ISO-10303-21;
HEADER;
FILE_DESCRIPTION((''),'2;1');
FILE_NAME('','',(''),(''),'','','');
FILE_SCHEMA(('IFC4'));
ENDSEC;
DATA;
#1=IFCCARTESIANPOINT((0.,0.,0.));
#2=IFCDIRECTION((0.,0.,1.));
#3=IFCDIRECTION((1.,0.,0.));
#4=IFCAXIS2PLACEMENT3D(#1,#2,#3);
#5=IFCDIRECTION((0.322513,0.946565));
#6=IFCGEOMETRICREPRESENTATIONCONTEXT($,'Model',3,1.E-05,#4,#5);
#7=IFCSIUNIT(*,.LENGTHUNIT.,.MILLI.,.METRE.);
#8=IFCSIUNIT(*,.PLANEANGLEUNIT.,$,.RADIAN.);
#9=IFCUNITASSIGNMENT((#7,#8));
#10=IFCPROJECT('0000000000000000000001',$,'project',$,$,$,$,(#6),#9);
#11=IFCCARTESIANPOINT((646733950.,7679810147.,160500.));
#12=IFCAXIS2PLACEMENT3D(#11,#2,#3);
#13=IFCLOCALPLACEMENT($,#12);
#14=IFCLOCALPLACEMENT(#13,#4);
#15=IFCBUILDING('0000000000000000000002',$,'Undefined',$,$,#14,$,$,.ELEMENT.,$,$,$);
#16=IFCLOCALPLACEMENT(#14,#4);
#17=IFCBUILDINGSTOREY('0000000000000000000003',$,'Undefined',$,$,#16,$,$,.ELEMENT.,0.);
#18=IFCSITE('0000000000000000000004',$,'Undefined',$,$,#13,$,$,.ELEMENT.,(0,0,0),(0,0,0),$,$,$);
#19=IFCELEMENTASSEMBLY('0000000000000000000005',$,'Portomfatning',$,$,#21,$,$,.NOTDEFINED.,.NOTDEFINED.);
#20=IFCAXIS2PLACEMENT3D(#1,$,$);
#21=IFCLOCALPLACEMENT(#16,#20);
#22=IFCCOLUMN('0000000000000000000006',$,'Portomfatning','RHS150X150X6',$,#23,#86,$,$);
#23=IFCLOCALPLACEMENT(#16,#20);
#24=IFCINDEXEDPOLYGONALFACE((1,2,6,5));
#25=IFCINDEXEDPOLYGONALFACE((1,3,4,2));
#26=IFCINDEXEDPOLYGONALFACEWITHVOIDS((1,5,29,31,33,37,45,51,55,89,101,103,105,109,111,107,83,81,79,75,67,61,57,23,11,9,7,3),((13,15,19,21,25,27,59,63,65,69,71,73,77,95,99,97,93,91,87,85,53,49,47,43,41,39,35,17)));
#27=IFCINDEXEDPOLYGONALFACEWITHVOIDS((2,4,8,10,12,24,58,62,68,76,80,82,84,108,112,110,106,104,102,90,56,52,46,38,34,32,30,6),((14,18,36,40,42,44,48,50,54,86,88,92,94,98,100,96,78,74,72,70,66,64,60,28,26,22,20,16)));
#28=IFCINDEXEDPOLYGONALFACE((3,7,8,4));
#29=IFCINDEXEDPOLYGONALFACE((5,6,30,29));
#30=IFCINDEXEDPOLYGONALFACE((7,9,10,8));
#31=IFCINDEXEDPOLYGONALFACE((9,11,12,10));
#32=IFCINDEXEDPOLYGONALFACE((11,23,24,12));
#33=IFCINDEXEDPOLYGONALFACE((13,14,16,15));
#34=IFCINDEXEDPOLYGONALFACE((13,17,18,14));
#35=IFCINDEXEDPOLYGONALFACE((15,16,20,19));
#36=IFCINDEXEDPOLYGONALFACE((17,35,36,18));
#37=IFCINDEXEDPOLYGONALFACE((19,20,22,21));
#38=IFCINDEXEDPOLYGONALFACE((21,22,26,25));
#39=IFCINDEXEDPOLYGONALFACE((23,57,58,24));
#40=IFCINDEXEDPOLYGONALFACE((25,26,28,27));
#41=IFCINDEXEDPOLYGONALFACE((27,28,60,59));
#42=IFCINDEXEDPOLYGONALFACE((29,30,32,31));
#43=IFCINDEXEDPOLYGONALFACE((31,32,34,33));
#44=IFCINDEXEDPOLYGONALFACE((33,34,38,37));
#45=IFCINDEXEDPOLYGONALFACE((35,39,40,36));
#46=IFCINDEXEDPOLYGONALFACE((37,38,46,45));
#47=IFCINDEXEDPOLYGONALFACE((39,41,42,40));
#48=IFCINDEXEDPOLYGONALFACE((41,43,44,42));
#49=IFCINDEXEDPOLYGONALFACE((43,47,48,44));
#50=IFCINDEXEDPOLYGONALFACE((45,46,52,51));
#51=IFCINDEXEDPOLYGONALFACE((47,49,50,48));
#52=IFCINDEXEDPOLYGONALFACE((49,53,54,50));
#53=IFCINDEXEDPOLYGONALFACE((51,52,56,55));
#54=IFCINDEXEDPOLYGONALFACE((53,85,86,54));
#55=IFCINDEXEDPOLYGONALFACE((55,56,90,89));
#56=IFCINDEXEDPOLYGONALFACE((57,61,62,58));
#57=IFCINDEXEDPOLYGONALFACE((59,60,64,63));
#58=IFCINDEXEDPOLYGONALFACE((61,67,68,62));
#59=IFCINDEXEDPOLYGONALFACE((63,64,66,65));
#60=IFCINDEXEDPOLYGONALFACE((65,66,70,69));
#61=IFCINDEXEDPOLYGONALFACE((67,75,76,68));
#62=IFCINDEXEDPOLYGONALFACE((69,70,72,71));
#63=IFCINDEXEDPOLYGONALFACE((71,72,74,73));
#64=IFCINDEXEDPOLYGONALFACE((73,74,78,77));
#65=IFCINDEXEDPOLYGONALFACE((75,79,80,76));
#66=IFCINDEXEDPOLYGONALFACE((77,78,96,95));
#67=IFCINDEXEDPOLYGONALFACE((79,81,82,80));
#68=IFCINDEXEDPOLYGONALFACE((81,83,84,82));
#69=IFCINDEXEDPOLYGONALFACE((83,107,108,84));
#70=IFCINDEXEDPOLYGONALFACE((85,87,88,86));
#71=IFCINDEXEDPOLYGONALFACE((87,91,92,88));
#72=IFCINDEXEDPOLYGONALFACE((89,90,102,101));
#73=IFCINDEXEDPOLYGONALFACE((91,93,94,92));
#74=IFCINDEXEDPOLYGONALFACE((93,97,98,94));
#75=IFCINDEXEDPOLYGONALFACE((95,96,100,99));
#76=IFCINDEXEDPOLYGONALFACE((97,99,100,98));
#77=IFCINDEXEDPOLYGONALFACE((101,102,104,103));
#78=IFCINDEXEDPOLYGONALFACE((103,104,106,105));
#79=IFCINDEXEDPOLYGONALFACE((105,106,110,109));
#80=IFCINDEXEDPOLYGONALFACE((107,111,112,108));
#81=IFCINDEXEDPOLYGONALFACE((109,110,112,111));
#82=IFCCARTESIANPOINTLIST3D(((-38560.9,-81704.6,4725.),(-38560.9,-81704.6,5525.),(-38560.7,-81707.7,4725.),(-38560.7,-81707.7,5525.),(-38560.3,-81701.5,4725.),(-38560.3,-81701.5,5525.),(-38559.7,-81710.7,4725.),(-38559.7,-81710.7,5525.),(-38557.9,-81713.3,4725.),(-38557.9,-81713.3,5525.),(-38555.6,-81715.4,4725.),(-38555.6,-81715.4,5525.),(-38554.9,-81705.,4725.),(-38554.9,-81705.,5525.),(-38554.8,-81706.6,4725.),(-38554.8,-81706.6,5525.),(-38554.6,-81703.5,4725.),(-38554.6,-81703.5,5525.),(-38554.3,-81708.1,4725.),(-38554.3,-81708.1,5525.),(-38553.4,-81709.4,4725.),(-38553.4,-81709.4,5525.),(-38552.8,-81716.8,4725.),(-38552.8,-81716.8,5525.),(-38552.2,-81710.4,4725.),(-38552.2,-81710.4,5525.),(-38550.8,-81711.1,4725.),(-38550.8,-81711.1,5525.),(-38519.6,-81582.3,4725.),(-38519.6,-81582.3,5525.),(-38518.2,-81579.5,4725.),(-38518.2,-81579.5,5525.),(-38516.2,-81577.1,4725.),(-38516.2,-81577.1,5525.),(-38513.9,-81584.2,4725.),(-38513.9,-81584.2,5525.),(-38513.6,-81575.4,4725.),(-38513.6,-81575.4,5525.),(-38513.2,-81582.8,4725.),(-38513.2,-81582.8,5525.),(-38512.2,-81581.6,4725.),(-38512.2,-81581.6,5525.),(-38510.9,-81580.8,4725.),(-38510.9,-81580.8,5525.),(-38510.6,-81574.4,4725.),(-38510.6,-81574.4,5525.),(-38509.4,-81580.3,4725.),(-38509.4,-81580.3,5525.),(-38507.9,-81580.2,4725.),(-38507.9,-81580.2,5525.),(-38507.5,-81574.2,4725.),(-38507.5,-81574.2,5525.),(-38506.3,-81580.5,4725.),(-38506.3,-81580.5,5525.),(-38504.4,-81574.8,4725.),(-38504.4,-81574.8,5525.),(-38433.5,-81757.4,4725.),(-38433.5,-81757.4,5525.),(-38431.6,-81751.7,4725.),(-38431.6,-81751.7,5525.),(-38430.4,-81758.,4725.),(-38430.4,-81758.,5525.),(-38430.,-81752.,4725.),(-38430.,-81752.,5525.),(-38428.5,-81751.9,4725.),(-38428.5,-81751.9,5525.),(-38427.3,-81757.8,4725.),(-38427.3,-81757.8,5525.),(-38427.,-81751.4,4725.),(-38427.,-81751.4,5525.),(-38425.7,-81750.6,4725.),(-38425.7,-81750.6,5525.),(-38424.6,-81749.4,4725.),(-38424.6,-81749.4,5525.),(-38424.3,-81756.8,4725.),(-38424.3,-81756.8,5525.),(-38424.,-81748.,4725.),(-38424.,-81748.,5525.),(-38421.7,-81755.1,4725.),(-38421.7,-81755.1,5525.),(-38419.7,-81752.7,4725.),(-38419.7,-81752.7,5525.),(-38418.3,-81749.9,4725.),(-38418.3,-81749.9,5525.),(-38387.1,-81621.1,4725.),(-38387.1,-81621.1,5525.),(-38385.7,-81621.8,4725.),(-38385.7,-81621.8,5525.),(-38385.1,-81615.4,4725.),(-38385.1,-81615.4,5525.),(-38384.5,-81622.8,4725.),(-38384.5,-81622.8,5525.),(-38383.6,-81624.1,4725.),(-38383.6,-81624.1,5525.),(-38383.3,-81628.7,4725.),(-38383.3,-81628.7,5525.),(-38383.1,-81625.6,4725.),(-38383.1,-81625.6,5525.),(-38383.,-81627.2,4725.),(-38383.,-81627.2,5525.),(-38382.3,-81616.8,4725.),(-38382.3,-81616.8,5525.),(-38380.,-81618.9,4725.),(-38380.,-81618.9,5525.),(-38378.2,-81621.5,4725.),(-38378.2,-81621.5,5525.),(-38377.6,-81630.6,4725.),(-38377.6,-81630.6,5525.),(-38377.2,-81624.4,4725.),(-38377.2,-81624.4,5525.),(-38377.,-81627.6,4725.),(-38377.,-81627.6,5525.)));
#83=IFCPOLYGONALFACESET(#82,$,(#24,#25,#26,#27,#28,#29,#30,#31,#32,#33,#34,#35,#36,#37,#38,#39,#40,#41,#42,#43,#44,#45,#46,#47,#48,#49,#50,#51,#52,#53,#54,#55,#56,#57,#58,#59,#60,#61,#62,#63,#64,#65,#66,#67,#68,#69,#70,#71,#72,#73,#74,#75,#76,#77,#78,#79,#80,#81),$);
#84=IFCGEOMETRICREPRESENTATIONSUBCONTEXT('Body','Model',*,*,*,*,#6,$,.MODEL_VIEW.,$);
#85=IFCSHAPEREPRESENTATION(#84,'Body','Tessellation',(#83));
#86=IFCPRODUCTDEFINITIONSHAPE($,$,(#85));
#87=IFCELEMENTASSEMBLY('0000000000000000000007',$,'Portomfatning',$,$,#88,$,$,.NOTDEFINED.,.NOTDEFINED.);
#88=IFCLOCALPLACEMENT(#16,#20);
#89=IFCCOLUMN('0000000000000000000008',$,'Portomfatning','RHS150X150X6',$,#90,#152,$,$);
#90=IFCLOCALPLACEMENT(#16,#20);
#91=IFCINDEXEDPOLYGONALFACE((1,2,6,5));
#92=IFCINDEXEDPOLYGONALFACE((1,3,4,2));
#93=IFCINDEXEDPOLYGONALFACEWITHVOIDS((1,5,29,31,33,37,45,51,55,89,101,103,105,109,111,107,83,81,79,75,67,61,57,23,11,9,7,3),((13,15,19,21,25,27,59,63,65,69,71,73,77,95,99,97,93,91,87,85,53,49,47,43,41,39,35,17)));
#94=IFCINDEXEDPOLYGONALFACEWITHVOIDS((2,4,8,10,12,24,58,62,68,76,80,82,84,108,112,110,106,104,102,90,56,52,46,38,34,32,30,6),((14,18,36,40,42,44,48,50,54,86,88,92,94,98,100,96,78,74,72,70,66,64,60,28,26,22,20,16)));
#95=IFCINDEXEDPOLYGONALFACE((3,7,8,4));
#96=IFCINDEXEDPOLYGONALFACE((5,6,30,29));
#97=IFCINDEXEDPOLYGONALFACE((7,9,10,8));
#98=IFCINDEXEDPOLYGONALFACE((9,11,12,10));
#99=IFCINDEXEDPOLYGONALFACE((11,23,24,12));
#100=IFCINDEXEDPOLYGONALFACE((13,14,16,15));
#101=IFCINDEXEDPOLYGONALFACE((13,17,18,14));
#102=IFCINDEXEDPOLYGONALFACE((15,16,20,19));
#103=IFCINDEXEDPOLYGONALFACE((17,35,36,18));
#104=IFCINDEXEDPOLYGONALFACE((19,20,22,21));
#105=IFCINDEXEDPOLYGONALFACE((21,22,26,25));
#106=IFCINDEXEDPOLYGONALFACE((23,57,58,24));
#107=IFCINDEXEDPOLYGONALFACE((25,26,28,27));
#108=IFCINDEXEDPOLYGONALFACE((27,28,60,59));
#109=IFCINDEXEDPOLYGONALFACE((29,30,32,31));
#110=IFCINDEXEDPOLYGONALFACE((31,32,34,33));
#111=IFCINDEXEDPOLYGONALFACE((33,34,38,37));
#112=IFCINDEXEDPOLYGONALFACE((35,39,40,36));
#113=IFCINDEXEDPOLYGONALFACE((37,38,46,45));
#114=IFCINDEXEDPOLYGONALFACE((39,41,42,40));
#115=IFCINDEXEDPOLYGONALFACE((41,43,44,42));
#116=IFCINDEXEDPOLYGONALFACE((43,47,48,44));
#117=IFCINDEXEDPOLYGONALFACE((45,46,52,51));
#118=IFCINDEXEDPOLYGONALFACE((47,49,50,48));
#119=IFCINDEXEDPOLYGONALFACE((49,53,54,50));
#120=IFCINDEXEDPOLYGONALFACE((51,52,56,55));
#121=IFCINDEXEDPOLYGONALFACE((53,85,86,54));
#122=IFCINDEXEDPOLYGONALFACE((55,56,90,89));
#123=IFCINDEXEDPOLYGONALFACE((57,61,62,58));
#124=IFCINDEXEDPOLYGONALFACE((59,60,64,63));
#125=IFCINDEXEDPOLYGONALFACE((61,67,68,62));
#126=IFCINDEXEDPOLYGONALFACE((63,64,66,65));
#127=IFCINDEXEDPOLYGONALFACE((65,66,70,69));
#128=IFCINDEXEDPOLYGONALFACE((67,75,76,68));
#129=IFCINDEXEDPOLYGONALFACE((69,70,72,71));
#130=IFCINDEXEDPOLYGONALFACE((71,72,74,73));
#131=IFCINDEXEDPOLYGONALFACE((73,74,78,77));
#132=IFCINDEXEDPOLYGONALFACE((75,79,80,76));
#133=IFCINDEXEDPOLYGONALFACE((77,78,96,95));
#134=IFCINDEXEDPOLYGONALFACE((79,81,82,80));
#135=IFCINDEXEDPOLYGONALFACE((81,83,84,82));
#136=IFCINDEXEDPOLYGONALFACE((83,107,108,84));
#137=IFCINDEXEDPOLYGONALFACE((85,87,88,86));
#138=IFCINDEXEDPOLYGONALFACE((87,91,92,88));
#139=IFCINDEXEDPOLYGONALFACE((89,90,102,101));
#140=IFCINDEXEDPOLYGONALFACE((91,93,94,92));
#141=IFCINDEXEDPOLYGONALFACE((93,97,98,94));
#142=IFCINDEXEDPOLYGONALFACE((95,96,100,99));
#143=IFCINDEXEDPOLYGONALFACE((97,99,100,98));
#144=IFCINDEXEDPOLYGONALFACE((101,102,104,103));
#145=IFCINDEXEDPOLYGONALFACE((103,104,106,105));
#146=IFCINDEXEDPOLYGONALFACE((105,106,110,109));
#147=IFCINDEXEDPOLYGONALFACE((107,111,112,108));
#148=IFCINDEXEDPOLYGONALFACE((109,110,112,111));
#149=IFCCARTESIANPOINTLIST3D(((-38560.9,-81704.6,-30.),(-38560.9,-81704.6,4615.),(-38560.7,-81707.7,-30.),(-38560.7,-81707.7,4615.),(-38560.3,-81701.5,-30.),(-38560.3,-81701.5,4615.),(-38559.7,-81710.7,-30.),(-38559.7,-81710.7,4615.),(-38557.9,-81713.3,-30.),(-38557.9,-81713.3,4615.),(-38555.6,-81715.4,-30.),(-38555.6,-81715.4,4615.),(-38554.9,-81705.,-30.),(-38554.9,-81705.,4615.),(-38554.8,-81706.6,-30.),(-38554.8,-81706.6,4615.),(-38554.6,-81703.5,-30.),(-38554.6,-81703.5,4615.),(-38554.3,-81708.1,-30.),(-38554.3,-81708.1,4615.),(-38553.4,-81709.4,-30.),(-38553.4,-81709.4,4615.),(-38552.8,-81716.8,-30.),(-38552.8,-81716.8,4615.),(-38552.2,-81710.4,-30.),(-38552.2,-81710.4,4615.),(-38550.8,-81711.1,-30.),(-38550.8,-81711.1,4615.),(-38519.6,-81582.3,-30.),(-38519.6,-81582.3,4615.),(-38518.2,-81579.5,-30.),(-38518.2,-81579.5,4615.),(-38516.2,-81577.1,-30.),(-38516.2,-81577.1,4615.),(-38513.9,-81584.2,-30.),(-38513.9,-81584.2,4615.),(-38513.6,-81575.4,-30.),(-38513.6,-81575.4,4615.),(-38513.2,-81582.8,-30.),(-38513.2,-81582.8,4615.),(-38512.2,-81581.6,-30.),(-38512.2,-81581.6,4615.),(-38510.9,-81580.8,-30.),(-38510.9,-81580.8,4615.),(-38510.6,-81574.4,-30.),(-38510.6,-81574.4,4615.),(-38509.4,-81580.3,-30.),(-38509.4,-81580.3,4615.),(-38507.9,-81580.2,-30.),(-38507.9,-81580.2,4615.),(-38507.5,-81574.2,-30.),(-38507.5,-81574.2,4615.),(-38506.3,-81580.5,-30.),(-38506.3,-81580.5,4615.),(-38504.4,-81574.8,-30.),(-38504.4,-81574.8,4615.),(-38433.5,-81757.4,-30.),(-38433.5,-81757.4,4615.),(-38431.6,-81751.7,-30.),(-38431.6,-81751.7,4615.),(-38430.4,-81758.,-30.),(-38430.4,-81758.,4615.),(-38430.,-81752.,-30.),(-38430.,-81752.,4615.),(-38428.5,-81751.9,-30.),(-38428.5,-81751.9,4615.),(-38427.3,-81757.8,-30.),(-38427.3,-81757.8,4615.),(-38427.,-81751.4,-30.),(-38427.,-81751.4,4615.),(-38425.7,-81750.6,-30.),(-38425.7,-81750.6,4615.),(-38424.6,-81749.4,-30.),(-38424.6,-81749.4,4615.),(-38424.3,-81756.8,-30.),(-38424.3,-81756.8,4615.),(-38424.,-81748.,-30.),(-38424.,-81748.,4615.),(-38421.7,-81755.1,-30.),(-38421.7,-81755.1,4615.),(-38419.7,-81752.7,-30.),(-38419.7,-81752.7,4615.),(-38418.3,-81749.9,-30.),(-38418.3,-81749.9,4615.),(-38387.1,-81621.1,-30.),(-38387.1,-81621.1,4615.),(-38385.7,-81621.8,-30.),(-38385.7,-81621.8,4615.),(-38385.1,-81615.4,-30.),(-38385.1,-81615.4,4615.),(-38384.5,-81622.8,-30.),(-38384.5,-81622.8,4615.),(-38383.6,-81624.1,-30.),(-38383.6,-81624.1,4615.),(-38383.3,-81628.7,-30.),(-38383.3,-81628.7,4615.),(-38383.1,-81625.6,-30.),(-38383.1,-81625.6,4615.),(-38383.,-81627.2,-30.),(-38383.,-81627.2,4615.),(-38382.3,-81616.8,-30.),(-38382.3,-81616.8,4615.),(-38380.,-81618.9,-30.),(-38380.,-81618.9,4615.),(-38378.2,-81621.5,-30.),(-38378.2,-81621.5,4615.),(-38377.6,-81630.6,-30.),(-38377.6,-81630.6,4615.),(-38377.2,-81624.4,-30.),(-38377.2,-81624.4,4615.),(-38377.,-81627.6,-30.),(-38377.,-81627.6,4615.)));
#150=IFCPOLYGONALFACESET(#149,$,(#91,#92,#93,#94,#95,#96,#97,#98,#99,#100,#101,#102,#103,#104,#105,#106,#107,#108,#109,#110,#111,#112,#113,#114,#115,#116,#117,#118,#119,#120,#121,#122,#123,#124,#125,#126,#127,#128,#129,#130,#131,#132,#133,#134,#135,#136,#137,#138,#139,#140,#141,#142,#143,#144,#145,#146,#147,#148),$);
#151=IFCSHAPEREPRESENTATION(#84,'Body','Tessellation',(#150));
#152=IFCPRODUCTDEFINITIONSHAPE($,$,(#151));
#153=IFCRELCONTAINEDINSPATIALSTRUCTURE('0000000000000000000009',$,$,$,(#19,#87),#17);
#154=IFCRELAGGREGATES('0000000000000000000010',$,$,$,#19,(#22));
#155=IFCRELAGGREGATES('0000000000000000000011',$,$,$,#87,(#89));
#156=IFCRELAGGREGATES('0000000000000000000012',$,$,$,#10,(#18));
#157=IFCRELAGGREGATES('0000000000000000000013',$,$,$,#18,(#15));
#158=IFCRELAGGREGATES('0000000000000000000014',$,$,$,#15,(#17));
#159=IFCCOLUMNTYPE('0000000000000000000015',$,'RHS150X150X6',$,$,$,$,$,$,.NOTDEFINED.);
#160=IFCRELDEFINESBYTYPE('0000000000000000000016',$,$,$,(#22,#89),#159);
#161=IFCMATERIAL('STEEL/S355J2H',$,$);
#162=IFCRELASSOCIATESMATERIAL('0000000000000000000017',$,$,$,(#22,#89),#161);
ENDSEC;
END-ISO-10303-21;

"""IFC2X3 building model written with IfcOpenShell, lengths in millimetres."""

from ifc_helpers import new_model, si_unit, direction, frame, origin_with_axes, origin_2d_with_axis, place, context, subcontext, project, spatial, hollow_rectangle, extrude, clip, halfspace, material, type_object, element, aggregate, save


model = new_model("IFC2X3")

# Units and contexts
model_context = context("Model", 3, precision=1e-05, world=origin_with_axes(), true_north=direction((0.322513, 0.946565)))
body_context = subcontext(model_context, "Body", "Model", "MODEL_VIEW")
ifc_project = project(units=[si_unit("LENGTHUNIT", "METRE", prefix="MILLI"), si_unit("PLANEANGLEUNIT", "RADIAN")], contexts=[model_context])

# Site, building, storey
site_placement = place(None, frame((646733950.0, 7679810147.0, 160500.0), z_axis=(0.0, 0.0, 1.0), x_axis=(1.0, 0.0, 0.0)))
site = spatial("IfcSite", under=ifc_project, at=site_placement, Name="Undefined", CompositionType="ELEMENT", RefLatitude=(0, 0, 0), RefLongitude=(0, 0, 0))
building_placement = place(site_placement, origin_with_axes())
building = spatial("IfcBuilding", under=site, at=building_placement, Name="Undefined", CompositionType="ELEMENT")
storey_placement = place(building_placement, origin_with_axes())
storey = spatial("IfcBuildingStorey", under=building, at=storey_placement, Name="Undefined", CompositionType="ELEMENT", Elevation=0.0)

# Element assembly, column
assembly_1_placement = place(storey_placement, origin_with_axes())
assembly_1 = element("IfcElementAssembly", 1, at=assembly_1_placement, inside=storey, Name="Portomfatning", AssemblyPlace="NOTDEFINED", PredefinedType="NOTDEFINED")
ifc_material_1 = material(Name="STEEL/S355J2H")
column_type_1 = type_object("IfcColumnType", Name="RHS150X150X6", PredefinedType="NOTDEFINED")
column_1_placement = place(assembly_1_placement, frame((-38468.9, -81666.1, 4725.0), z_axis=(0.0, 0.0, 1.0), x_axis=(0.946565, -0.322513, 0.0)))
column_1 = element("IfcColumn", 2, at=column_1_placement, type_object=column_type_1, material=ifc_material_1, Name="Portomfatning", Description="RHS150X150X6", context=body_context, shape_type="SweptSolid", body=[
    extrude(hollow_rectangle(XDim=150.0, YDim=150.0, WallThickness=6.0, InnerFilletRadius=6.0, OuterFilletRadius=12.0, at=origin_2d_with_axis()), frame((0.0, 0.0, 800.0), z_axis=(0.0, 0.0, -1.0), x_axis=(0.0, 1.0, 0.0)), (0.0, 0.0, 1.0), 800.0),
])

# Element assembly, column
assembly_2_placement = place(storey_placement, origin_with_axes())
assembly_2 = element("IfcElementAssembly", 3, at=assembly_2_placement, inside=storey, Name="Portomfatning", AssemblyPlace="NOTDEFINED", PredefinedType="NOTDEFINED")
column_2_placement = place(assembly_2_placement, frame((-38468.9, -81666.1, -30.0), z_axis=(0.0, 0.0, 1.0), x_axis=(0.946565, -0.322513, 0.0)))
column_2 = element("IfcColumn", 4, at=column_2_placement, type_object=column_type_1, material=ifc_material_1, Name="Portomfatning", Description="RHS150X150X6", context=body_context, shape_type="Clipping", body=[
    clip(extrude(hollow_rectangle(XDim=150.0, YDim=150.0, WallThickness=6.0, InnerFilletRadius=6.0, OuterFilletRadius=12.0, at=origin_2d_with_axis()), frame((0.0, 0.0, 4655.0), z_axis=(0.0, 0.0, -1.0), x_axis=(0.0, 1.0, 0.0)), (0.0, 0.0, 1.0), 4655.0), halfspace(frame((0.0, 75.0, 4645.0), z_axis=(0.0, 0.0, -1.0), x_axis=(-1.0, 0.0, 0.0)), True)),
])

aggregate(assembly_1, [column_1])

aggregate(assembly_2, [column_2])

save(model, "model.ifc")
